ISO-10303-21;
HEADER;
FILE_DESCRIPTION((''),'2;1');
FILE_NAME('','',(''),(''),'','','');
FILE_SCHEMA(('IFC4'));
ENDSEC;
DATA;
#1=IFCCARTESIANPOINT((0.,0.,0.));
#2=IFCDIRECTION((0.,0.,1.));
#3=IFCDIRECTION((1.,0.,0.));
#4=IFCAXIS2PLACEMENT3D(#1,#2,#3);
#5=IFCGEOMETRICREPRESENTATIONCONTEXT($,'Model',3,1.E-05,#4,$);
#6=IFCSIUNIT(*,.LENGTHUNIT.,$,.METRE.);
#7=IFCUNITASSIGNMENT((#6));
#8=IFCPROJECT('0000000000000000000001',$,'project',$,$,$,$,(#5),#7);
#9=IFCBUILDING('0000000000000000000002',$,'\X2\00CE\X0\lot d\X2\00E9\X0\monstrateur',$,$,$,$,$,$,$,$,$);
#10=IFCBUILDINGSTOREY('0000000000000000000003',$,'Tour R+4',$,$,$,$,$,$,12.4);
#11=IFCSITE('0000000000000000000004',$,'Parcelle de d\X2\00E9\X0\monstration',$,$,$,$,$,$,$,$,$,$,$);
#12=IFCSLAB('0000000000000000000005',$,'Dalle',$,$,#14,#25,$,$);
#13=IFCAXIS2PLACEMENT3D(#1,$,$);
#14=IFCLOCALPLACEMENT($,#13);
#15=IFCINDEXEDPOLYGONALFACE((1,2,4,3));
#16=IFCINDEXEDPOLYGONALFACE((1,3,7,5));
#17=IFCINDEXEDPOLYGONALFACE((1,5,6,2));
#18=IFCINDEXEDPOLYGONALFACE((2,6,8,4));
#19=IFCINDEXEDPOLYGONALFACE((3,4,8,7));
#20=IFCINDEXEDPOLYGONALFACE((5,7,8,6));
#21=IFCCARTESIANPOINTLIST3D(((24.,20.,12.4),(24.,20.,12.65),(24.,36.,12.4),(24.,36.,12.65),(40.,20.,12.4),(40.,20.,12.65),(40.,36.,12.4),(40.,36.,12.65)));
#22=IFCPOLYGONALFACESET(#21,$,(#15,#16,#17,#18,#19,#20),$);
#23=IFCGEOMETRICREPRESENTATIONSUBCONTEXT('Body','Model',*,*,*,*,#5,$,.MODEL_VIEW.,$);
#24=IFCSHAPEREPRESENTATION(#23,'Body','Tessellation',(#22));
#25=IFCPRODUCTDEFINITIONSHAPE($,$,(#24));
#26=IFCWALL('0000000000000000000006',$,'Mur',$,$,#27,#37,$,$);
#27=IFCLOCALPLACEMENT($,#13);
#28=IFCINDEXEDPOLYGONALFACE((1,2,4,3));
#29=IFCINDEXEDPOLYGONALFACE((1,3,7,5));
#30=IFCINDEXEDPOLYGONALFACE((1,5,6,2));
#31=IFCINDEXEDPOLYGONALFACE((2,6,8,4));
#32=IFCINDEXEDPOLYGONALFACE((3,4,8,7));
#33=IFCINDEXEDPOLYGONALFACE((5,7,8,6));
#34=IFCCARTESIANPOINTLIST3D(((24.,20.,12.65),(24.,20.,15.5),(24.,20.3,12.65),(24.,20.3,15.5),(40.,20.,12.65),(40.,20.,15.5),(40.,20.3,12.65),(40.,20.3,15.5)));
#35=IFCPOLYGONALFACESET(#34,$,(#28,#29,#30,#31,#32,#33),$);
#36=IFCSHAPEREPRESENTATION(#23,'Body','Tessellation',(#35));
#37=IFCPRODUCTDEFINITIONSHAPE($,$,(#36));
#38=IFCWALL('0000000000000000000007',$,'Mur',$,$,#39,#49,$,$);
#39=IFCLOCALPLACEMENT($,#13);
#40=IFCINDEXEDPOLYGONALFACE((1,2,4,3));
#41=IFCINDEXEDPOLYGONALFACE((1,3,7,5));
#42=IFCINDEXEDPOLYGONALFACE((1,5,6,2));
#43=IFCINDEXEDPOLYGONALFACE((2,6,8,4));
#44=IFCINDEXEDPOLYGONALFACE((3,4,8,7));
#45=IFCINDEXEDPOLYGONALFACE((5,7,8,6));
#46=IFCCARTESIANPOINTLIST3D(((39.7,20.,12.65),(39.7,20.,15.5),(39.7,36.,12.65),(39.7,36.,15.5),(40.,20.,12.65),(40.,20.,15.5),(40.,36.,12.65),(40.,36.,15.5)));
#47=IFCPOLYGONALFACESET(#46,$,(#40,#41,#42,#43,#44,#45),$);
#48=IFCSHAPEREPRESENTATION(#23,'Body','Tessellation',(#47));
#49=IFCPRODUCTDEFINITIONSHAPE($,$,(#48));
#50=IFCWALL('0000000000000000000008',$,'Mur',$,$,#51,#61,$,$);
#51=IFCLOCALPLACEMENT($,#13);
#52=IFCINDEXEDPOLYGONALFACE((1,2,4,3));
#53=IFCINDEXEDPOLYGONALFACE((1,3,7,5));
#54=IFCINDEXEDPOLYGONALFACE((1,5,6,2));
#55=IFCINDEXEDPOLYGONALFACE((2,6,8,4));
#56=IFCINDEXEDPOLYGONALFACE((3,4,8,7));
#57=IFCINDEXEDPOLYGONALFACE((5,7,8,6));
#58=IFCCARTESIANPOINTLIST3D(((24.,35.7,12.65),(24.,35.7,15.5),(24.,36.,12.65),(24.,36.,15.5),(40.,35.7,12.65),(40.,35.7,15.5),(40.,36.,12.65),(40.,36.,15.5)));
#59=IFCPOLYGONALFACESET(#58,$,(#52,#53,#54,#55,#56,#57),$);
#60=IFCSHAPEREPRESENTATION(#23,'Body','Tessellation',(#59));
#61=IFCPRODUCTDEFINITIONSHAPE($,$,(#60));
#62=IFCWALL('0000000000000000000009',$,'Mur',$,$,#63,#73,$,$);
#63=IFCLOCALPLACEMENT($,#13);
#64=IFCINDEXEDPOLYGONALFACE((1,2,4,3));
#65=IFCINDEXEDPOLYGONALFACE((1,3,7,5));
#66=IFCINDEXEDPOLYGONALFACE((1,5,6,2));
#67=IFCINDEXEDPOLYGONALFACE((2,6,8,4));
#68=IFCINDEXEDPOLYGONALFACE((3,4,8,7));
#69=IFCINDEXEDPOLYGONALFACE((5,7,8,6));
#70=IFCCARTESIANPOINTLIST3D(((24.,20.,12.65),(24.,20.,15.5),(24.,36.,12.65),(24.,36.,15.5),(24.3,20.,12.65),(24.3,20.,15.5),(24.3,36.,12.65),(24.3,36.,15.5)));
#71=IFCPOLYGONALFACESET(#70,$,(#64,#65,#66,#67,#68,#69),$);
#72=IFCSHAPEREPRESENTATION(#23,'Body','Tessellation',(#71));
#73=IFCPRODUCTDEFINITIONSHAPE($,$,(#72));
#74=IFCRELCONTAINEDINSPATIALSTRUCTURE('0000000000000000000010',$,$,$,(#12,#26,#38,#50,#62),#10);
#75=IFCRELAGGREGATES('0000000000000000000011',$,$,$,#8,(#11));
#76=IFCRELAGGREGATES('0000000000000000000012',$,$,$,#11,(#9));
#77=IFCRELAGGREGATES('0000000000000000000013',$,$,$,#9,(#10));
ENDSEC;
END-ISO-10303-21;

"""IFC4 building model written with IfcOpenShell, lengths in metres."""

from ifc_helpers import new_model, si_unit, frame, origin_with_axes, place, context, subcontext, project, spatial, indexed_curve, outline, extrude, element, save


model = new_model("IFC4")

# Units and contexts
model_context = context("Model", 3, precision=1e-05, world=origin_with_axes())
body_context = subcontext(model_context, "Body", "Model", "MODEL_VIEW")
ifc_project = project(units=[si_unit("LENGTHUNIT", "METRE")], contexts=[model_context])

# Site, building, storey
site = spatial("IfcSite", under=ifc_project, Name="Parcelle de démonstration")
building = spatial("IfcBuilding", under=site, Name="Îlot démonstrateur")
storey = spatial("IfcBuildingStorey", under=building, Name="Tour R+4", Elevation=12.4)

# Slab
slab_placement = place(None, frame((0.0, 0.0, 12.4), z_axis=(0.0, 0.0, 1.0), x_axis=(1.0, 0.0, 0.0)))
element("IfcSlab", 1, at=slab_placement, inside=storey, Name="Dalle", context=body_context, shape_type="SweptSolid", body=[
    extrude(outline(indexed_curve([(24.0, 20.0), (40.0, 20.0), (40.0, 36.0), (24.0, 36.0)])), None, (0.0, 0.0, 1.0), 0.25),
])

# Walls
for number, where, z_axis, x_axis, name in (
    (2, (24.0, 20.0, 12.65), (0.0, 0.0, 1.0), (1.0, 0.0, 0.0), "Mur"),
    (3, (40.0, 20.0, 12.65), (0.0, 0.0, 1.0), (0.0, 1.0, 0.0), "Mur"),
    (4, (40.0, 36.0, 12.65), (0.0, 0.0, 1.0), (-1.0, 0.0, 0.0), "Mur"),
    (5, (24.0, 36.0, 12.65), (0.0, 0.0, 1.0), (0.0, -1.0, 0.0), "Mur"),
):
    element("IfcWall", number, at=place(None, frame(where, z_axis=z_axis, x_axis=x_axis)), inside=storey, Name=name, context=body_context, shape_type="SweptSolid", body=[
        extrude(outline(indexed_curve([(0.0, 0.0), (0.0, 0.3), (16.0, 0.3), (16.0, 0.0), (0.0, 0.0)], self_intersect=False)), origin_with_axes(), (0.0, 0.0, 1.0), 2.85),
    ])

save(model, "model.ifc")
